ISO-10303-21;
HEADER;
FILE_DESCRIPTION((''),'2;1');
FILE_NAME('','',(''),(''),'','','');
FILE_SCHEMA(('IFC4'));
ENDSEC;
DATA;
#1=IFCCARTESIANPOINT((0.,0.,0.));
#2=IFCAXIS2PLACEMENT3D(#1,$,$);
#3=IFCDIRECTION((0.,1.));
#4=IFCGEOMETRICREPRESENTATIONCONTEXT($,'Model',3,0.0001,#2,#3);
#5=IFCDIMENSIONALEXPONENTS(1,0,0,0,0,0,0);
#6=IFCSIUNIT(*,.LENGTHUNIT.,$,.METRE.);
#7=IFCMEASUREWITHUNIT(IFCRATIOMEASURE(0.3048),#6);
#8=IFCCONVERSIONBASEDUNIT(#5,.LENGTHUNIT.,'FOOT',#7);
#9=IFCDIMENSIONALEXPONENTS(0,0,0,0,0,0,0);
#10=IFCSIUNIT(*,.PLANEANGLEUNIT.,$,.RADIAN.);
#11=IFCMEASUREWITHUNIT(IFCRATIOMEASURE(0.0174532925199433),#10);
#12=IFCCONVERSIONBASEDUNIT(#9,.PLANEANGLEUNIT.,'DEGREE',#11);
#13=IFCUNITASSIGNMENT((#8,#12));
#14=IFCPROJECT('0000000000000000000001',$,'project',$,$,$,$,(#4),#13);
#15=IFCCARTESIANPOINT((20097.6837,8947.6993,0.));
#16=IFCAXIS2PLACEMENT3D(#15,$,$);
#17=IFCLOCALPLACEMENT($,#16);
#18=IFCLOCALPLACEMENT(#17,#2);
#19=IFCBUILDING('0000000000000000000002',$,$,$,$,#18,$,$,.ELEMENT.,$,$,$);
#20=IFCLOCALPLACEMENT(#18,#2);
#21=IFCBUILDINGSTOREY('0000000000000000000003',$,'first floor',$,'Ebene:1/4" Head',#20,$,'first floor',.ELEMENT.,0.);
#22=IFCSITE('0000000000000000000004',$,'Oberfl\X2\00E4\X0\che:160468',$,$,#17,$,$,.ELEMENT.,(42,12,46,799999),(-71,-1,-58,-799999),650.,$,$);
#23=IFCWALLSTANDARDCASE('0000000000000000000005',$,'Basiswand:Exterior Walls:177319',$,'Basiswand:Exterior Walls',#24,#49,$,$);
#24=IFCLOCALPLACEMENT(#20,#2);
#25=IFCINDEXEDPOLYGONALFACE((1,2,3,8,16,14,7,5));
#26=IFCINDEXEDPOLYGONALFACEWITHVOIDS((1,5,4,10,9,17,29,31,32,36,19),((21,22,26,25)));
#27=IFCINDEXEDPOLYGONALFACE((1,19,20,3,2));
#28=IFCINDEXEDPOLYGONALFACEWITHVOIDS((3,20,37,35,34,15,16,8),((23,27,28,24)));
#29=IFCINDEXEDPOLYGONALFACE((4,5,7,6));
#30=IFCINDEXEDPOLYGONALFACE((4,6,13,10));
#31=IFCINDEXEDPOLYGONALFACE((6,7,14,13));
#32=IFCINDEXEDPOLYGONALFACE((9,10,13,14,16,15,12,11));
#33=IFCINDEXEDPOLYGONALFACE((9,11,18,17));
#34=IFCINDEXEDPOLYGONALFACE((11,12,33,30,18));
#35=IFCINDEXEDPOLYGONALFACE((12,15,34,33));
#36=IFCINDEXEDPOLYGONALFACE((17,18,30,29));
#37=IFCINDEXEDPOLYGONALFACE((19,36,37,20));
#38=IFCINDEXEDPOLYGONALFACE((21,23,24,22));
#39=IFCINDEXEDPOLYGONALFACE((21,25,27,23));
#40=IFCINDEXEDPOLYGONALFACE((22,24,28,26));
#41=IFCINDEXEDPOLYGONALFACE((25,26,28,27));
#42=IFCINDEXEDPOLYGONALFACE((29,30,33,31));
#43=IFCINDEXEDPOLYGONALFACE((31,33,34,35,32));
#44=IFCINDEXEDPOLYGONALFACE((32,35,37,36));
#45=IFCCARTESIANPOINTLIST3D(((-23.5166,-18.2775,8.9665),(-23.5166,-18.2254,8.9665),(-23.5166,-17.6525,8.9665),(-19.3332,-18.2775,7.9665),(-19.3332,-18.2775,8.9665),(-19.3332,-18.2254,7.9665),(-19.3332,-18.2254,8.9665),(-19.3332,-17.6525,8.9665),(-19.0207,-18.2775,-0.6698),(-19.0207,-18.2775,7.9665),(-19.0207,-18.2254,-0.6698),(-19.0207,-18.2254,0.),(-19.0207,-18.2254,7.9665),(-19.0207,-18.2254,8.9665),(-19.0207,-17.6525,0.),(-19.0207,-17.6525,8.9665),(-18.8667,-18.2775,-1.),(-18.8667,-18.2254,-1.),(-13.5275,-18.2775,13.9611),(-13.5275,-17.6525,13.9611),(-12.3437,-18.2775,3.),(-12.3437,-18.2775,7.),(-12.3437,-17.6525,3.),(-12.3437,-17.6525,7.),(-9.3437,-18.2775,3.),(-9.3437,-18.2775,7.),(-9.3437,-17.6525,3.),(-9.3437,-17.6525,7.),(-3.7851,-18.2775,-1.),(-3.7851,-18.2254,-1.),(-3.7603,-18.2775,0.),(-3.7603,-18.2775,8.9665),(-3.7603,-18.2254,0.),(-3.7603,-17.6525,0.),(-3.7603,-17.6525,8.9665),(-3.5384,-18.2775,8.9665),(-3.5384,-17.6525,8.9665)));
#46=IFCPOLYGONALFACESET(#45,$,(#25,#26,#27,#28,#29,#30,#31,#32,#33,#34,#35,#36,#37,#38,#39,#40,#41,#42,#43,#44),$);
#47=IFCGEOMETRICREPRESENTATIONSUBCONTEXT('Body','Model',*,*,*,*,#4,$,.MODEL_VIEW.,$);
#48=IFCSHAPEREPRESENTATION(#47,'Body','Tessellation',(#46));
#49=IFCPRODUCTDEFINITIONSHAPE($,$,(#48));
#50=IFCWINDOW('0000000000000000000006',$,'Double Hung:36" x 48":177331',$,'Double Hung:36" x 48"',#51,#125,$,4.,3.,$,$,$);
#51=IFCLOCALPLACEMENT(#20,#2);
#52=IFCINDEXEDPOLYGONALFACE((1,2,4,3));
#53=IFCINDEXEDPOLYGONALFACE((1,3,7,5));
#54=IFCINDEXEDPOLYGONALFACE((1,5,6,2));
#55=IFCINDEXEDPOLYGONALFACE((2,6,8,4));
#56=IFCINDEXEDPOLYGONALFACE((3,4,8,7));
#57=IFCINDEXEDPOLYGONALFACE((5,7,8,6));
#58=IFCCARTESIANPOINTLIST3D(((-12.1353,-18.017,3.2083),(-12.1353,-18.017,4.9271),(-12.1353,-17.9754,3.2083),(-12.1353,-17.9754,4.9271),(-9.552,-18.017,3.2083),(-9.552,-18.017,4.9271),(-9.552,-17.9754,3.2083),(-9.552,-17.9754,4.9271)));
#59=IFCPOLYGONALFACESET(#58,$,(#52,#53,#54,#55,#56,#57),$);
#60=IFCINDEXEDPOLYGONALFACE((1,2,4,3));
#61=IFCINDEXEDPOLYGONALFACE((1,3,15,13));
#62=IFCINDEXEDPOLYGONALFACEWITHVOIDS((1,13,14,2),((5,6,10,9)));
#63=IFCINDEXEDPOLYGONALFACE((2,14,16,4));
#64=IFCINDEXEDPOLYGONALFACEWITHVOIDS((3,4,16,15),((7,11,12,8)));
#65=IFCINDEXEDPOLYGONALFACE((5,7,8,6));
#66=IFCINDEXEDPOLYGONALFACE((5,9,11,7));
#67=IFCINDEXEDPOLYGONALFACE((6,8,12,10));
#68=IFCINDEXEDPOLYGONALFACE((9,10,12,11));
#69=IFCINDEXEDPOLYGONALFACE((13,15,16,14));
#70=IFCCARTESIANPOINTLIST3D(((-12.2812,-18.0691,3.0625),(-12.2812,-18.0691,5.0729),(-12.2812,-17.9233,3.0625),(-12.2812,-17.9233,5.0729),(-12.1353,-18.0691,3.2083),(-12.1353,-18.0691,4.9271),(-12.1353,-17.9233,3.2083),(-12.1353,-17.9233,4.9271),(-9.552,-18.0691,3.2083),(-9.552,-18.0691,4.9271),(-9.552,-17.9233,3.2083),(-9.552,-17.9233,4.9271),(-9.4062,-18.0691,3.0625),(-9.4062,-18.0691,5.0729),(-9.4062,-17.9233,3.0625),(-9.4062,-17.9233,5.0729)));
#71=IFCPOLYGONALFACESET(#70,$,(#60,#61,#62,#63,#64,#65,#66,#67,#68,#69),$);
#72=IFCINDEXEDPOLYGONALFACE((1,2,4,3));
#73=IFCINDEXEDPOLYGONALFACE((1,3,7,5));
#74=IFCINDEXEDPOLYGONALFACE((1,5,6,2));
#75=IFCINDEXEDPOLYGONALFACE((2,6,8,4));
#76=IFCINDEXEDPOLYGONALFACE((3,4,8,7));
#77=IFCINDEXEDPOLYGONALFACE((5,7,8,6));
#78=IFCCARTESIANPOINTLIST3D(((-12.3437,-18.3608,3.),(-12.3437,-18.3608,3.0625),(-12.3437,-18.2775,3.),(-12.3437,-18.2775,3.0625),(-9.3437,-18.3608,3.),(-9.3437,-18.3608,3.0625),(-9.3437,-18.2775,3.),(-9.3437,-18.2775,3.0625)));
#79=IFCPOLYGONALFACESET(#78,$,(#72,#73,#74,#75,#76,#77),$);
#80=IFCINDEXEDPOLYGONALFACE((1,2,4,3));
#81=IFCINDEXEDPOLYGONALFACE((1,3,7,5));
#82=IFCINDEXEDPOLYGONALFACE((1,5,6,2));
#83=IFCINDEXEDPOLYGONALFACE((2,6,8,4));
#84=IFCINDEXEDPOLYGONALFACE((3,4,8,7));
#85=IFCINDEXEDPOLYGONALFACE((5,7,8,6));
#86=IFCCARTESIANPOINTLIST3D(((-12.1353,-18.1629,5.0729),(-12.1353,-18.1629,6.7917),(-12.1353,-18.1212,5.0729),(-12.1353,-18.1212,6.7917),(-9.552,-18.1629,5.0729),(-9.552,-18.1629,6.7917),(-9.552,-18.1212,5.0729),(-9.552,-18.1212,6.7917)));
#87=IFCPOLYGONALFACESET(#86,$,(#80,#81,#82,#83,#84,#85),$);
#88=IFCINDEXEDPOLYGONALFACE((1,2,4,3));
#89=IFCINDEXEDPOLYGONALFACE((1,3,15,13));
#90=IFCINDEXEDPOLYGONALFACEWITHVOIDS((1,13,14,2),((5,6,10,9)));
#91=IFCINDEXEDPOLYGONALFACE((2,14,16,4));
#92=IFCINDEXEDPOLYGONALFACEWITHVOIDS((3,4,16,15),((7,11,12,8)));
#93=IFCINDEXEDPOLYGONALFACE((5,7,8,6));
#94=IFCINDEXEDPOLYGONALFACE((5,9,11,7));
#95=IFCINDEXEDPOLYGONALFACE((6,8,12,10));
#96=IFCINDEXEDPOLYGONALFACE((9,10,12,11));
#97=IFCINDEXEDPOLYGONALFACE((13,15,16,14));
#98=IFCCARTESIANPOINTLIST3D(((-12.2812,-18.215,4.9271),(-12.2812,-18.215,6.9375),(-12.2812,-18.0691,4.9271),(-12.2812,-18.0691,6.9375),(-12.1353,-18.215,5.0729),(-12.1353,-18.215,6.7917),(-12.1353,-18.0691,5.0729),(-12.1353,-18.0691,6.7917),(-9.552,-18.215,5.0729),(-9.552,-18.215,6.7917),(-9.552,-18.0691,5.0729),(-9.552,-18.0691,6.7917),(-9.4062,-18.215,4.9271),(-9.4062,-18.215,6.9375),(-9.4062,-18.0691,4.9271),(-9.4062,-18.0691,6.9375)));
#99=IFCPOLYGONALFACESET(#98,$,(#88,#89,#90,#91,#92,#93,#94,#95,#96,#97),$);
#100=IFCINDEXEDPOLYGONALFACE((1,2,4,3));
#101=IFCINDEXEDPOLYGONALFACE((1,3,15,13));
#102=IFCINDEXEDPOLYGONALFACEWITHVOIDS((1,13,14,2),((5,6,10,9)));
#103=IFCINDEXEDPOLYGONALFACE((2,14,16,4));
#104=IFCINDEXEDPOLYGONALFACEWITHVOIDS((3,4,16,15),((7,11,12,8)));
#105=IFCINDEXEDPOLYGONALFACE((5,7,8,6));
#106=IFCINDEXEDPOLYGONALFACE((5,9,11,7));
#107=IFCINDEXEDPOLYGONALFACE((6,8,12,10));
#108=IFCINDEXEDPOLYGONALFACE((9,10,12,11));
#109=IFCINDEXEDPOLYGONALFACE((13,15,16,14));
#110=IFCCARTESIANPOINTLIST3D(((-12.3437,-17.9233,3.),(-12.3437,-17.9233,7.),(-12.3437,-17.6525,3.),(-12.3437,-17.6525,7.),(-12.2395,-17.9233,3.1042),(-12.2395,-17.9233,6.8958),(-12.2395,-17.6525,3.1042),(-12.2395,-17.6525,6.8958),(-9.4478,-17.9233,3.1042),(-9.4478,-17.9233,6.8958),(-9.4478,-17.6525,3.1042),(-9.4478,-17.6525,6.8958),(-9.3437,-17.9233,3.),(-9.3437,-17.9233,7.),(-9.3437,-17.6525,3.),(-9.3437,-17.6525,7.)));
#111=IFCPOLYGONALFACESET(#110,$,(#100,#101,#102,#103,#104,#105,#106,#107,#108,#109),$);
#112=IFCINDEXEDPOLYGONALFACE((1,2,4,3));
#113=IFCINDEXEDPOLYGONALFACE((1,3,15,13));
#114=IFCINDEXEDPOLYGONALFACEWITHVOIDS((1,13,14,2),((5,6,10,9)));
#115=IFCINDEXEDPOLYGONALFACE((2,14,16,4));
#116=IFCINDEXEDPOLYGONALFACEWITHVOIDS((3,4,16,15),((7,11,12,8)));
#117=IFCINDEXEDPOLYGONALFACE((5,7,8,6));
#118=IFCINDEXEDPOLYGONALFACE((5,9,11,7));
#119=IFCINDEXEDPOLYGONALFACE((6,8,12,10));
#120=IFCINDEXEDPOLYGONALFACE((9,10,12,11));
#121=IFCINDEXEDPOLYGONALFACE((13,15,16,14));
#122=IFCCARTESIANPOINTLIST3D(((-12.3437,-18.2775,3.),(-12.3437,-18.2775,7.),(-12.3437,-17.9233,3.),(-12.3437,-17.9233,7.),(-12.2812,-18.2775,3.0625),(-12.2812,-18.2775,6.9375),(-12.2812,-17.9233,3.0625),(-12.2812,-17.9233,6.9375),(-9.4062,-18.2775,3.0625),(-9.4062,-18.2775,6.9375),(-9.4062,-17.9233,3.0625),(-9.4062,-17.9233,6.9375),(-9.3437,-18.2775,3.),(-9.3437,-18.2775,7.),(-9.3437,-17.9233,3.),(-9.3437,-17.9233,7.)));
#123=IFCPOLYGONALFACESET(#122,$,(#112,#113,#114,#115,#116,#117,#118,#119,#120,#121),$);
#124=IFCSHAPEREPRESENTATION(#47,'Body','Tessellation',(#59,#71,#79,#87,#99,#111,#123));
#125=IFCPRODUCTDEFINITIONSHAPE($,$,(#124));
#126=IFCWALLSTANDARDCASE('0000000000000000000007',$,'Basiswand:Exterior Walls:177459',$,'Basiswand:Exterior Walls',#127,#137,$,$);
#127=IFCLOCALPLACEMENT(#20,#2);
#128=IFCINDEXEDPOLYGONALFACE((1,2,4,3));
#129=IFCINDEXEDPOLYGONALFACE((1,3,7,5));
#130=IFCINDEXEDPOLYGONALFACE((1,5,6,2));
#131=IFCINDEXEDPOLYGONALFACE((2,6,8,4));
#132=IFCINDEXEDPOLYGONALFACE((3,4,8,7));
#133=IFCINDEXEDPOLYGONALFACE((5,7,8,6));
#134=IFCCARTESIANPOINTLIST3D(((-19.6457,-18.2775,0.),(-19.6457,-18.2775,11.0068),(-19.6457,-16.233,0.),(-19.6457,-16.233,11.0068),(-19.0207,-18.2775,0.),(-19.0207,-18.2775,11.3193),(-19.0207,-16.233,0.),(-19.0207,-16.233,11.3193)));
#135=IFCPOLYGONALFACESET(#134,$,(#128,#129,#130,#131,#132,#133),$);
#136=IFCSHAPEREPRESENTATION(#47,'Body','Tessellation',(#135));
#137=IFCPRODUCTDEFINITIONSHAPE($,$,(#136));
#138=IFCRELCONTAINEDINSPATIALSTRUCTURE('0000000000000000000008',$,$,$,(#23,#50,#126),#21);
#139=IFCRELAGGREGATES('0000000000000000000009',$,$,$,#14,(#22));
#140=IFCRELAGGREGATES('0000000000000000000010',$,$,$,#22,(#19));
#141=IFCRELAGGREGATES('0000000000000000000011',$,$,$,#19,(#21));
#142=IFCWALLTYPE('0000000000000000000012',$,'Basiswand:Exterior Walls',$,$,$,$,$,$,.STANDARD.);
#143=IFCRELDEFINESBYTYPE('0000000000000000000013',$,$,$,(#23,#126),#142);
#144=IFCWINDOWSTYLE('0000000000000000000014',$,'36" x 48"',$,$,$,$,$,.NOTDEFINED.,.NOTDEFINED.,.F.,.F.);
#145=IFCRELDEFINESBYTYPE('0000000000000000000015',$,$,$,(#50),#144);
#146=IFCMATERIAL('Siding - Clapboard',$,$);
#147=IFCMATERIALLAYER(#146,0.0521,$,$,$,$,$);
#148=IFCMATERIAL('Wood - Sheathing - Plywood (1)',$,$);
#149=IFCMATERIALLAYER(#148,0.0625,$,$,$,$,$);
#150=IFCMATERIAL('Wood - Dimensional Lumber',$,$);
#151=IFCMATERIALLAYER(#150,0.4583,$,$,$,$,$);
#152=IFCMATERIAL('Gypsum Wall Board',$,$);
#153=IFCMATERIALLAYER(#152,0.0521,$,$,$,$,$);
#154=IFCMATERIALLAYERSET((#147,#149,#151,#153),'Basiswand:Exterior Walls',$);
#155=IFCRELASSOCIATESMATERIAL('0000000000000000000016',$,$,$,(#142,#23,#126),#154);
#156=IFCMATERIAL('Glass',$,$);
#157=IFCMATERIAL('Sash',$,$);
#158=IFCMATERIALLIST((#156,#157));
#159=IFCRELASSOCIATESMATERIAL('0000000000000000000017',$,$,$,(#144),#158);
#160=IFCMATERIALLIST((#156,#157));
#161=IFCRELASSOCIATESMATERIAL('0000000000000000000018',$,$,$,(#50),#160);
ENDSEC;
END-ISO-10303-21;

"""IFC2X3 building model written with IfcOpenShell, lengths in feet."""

from ifc_helpers import new_model, entity, si_unit, converted_unit, direction, frame, frame_2d, origin, origin_2d_with_axis, place, context, subcontext, project, spatial, polyline, rectangle, outline, extrude, clip, halfspace, bounded_halfspace, source, transform, mapped, material, material_list, layer, layer_set, layer_usage, type_object, type_shapes, element, fill, save


model = new_model("IFC2X3")

# Units and contexts
model_context = context("Model", 3, precision=0.0001, world=origin(), true_north=direction((0.0, 1.0)))
body_context = subcontext(model_context, "Body", "Model", "MODEL_VIEW")
ifc_project = project(units=[converted_unit("LENGTHUNIT", "FOOT", entity("IfcRatioMeasure", 0.3048), si_unit("LENGTHUNIT", "METRE"), dimensions=[1, 0, 0, 0, 0, 0, 0]), converted_unit("PLANEANGLEUNIT", "DEGREE", entity("IfcRatioMeasure", 0.0174532925199433), si_unit("PLANEANGLEUNIT", "RADIAN"), dimensions=[0, 0, 0, 0, 0, 0, 0])], contexts=[model_context])

# Site, building, storey
site_placement = place(None, frame((20097.6837, 8947.6993, 0.0)))
site = spatial("IfcSite", under=ifc_project, at=site_placement, Name="Oberfläche:160468", CompositionType="ELEMENT", RefLatitude=(42, 12, 46, 799999), RefLongitude=(-71, -1, -58, -799999), RefElevation=650.0)
building_placement = place(site_placement, origin())
building = spatial("IfcBuilding", under=site, at=building_placement, CompositionType="ELEMENT")
storey_placement = place(building_placement, origin())
storey = spatial("IfcBuildingStorey", under=building, at=storey_placement, Name="first floor", ObjectType="Ebene:1/4\" Head", LongName="first floor", CompositionType="ELEMENT", Elevation=0.0)

# Shared definitions
ifc_material_1 = material(Name="Wood - Sheathing - Plywood (1)")

# Shared definitions
ifc_material_2 = material(Name="Siding - Clapboard")
ifc_layer_1 = layer(ifc_material_2, 0.0521)
ifc_layer_2 = layer(ifc_material_1, 0.0625)
ifc_material_3 = material(Name="Wood - Dimensional Lumber")
ifc_layer_3 = layer(ifc_material_3, 0.4583)
ifc_material_4 = material(Name="Gypsum Wall Board")
ifc_layer_4 = layer(ifc_material_4, 0.0521)
ifc_layer_set_1 = layer_set([ifc_layer_1, ifc_layer_2, ifc_layer_3, ifc_layer_4], Name="Basiswand:Exterior Walls")
wall_type_1 = type_object("IfcWallType", Name="Basiswand:Exterior Walls", PredefinedType="STANDARD", material=ifc_layer_set_1)
ifc_material_5 = material(Name="Glass")
ifc_material_6 = material(Name="Sash")

# Wall, openings, window
ifc_layer_usage_1 = layer_usage(ifc_layer_set_1, "AXIS2", "NEGATIVE", 0.3125)
wall_1_placement = place(storey_placement, frame((-3.4478, -17.965, -1.0), z_axis=(0.0, 0.0, 1.0), x_axis=(-1.0, 0.0, 0.0)))
wall_1 = element("IfcWallStandardCase", 1, at=wall_1_placement, inside=storey, type_object=wall_type_1, material=ifc_layer_usage_1, Name="Basiswand:Exterior Walls:177319", ObjectType="Basiswand:Exterior Walls", context=body_context, shape_type="Clipping", body=[
    clip(clip(clip(clip(clip(clip(clip(extrude(rectangle(XDim=22.0688, YDim=0.625, at=frame_2d((11.0344, 0.0), x_axis=(-1.0, 0.0))), origin(), (0.0, 0.0, 1.0), 14.9611), bounded_halfspace(frame((15.5729, 0.2604, 8.9665), z_axis=(0.0, 0.0, 1.0), x_axis=(-1.0, 0.0, 0.0)), True, frame((15.5729, 0.2604, 8.9665)), polyline([(0.0, 0.0), (6.4959, 0.0), (6.4959, 0.0521), (0.0, 0.0521), (0.0, 0.0)]))), bounded_halfspace(frame((15.5729, -0.3125, 1.0), z_axis=(0.0, 0.0, -1.0), x_axis=(0.0, 1.0, 0.0)), False, frame((15.5729, -0.3125, 1.0)), polyline([(0.0, 0.0), (0.0, 0.5729), (-15.5208, 0.5729), (-15.5729, 0.5729), (-15.5729, 0.0), (-14.9479, 0.0), (-2.3854, 0.0), (-2.0104, 0.0), (0.0, 0.0)]))), bounded_halfspace(frame((20.0688, -0.3125, 9.9665), z_axis=(0.0, 0.0, -1.0), x_axis=(0.0, 1.0, 0.0)), False, frame((20.0688, -0.3125, 9.9665)), polyline([(0.0, 0.0), (0.0, 0.5729), (-4.4959, 0.5729), (-4.4959, 0.0), (0.0, 0.0)]))), halfspace(frame((10.0797, -0.3125, 14.9611), z_axis=(0.447214, 0.0, 0.894427), x_axis=(0.0, 1.0, 0.0)), False)), halfspace(frame((0.0905, -0.3125, 9.9665), z_axis=(-0.447214, 0.0, 0.894427), x_axis=(0.0, 1.0, 0.0)), False)), halfspace(frame((15.8854, 0.0, 1.0), z_axis=(0.906221, 0.0, -0.422805), x_axis=(0.0, 1.0, 0.0)), False)), halfspace(frame((0.0905, 0.0, 9.9665), z_axis=(-0.999694, 0.0, -0.024747), x_axis=(0.0, 1.0, 0.0)), False)),
])
opening_1_placement = place(wall_1_placement, origin())
element("IfcOpeningElement", 2, at=opening_1_placement, cuts=wall_1, ObjectType="Opening", context=body_context, shape_type="SweptSolid", body=[
    extrude(outline(polyline([(-6.0067, -1.2637), (3.8877, -1.2637), (2.119, 2.5274), (-6.0067, -1.2637)])), frame((17.2799, 0.3125, 6.9777), z_axis=(0.0, -1.0, 0.0), x_axis=(0.422805, 0.0, 0.906221)), (0.0, 0.0, 1.0), 0.625),
])
opening_2_placement = place(wall_1_placement, origin())
element("IfcOpeningElement", 3, at=opening_2_placement, cuts=wall_1, ObjectType="Opening", context=body_context, shape_type="SweptSolid", body=[
    extrude(outline(polyline([(-2.9916, -0.074), (5.9777, -0.074), (-2.9861, 0.1479), (-2.9916, -0.074)])), frame((0.2385, 0.3125, 6.9777), z_axis=(0.0, -1.0, 0.0), x_axis=(0.024747, 0.0, -0.999694)), (0.0, 0.0, 1.0), 0.625),
])
opening_3_placement = place(wall_1_placement, frame((5.8958, -0.3125, 4.0)))
opening_3 = element("IfcOpeningElement", 4, at=opening_3_placement, cuts=wall_1, ObjectType="Opening", context=body_context, shape_type="SweptSolid", body=[
    extrude(rectangle(XDim=4.0, YDim=3.0, at=frame_2d((2.0, 1.5), x_axis=(-1.0, 0.0))), frame((0.0, 0.0, 0.0), z_axis=(0.0, 1.0, 0.0), x_axis=(0.0, 0.0, 1.0)), (0.0, 0.0, 1.0), 0.625),
])
ifc_material_list_1 = material_list([ifc_material_5, ifc_material_6])
ifc_material_list_2 = material_list([ifc_material_5, ifc_material_6])
window_style_1 = type_object("IfcWindowStyle", Name="36\" x 48\"", ConstructionType="NOTDEFINED", OperationType="NOTDEFINED", ParameterTakesPrecedence=False, Sizeable=False, material=ifc_material_list_2)
shared_shape_1 = source(origin(), body_context, "Body", "SweptSolid", [
    extrude(rectangle(XDim=2.5833, YDim=0.0417, at=origin_2d_with_axis()), frame((1.5, 0.3438, 0.2083), z_axis=(0.0, 0.0, 1.0), x_axis=(-1.0, 0.0, 0.0)), (0.0, 0.0, 1.0), 1.7187),
    extrude(outline(polyline([(-1.4375, -1.0052), (1.4375, -1.0052), (1.4375, 1.0052), (-1.4375, 1.0052), (-1.4375, -1.0052)]), holes=[polyline([(-1.2917, -0.8594), (-1.2917, 0.8594), (1.2917, 0.8594), (1.2917, -0.8594), (-1.2917, -0.8594)])]), frame((1.5, 0.4167, 1.0677), z_axis=(0.0, -1.0, 0.0), x_axis=(-1.0, 0.0, 0.0)), (0.0, 0.0, 1.0), 0.1458),
    extrude(rectangle(XDim=3.0, YDim=0.0833, at=frame_2d((0.0, 0.0), x_axis=(1.0, 0.0))), frame((1.5, 0.6667, 0.0), z_axis=(0.0, 0.0, 1.0), x_axis=(-1.0, 0.0, 0.0)), (0.0, 0.0, 1.0), 0.0625),
    extrude(rectangle(XDim=2.5833, YDim=0.0417, at=frame_2d((0.0, 0.0), x_axis=(1.0, 0.0))), frame((1.5, 0.4896, 2.0729)), (0.0, 0.0, 1.0), 1.7188),
    extrude(outline(polyline([(-1.4375, -1.0052), (1.4375, -1.0052), (1.4375, 1.0052), (-1.4375, 1.0052), (-1.4375, -1.0052)]), holes=[polyline([(-1.2917, -0.8594), (-1.2917, 0.8594), (1.2917, 0.8594), (1.2917, -0.8594), (-1.2917, -0.8594)])]), frame((1.5, 0.5625, 2.9323), z_axis=(0.0, -1.0, 0.0), x_axis=(-1.0, 0.0, 0.0)), (0.0, 0.0, 1.0), 0.1458),
    extrude(outline(polyline([(-1.5, -2.0), (1.5, -2.0), (1.5, 2.0), (-1.5, 2.0), (-1.5, -2.0)]), holes=[polyline([(-1.3958, -1.8958), (-1.3958, 1.8958), (1.3958, 1.8958), (1.3958, -1.8958), (-1.3958, -1.8958)])]), frame((1.5, 0.2708, 2.0), z_axis=(0.0, -1.0, 0.0), x_axis=(-1.0, 0.0, 0.0)), (0.0, 0.0, 1.0), 0.2708),
    extrude(outline(polyline([(-2.0, -1.5), (2.0, -1.5), (2.0, 1.5), (-2.0, 1.5), (-2.0, -1.5)]), holes=[polyline([(-1.9375, -1.4375), (-1.9375, 1.4375), (1.9375, 1.4375), (1.9375, -1.4375), (-1.9375, -1.4375)])]), frame((1.5, 0.625, 2.0), z_axis=(0.0, -1.0, 0.0), x_axis=(0.0, 0.0, -1.0)), (0.0, 0.0, 1.0), 0.3542),
])
type_shapes(window_style_1, [shared_shape_1])
window_1_placement = place(opening_3_placement, origin())
window_1 = element("IfcWindow", 5, at=window_1_placement, inside=storey, type_object=window_style_1, material=ifc_material_list_1, Name="Double Hung:36\" x 48\":177331", ObjectType="Double Hung:36\" x 48\"", OverallHeight=4.0, OverallWidth=3.0, context=body_context, shape_type="MappedRepresentation", body=[
    mapped(shared_shape_1, transform((0.0, 0.0, 0.0), scale=1.0)),
])
fill(opening_3, window_1)

# Wall
ifc_layer_usage_2 = layer_usage(ifc_layer_set_1, "AXIS2", "POSITIVE", -0.3125)
wall_2_placement = place(storey_placement, frame((-19.3332, -16.233, 0.0), z_axis=(0.0, 0.0, 1.0), x_axis=(0.0, -1.0, 0.0)))
element("IfcWallStandardCase", 6, at=wall_2_placement, inside=storey, type_object=wall_type_1, material=ifc_layer_usage_2, Name="Basiswand:Exterior Walls:177459", ObjectType="Basiswand:Exterior Walls", context=body_context, shape_type="Clipping", body=[
    clip(extrude(rectangle(XDim=2.0445, YDim=0.625, at=frame_2d((1.0222, 0.0), x_axis=(-1.0, 0.0))), origin(), (0.0, 0.0, 1.0), 11.3193), bounded_halfspace(frame((0.0, -0.3125, 11.0068), z_axis=(0.0, -0.447214, 0.894427), x_axis=(1.0, 0.0, 0.0)), False, frame((0.0, -0.3125, 11.0068)), polyline([(0.0, 0.0), (0.625, 0.0), (2.0445, 0.0), (2.0445, 0.625), (0.0, 0.625), (0.0, 0.0)]))),
])

save(model, "model.ifc")
